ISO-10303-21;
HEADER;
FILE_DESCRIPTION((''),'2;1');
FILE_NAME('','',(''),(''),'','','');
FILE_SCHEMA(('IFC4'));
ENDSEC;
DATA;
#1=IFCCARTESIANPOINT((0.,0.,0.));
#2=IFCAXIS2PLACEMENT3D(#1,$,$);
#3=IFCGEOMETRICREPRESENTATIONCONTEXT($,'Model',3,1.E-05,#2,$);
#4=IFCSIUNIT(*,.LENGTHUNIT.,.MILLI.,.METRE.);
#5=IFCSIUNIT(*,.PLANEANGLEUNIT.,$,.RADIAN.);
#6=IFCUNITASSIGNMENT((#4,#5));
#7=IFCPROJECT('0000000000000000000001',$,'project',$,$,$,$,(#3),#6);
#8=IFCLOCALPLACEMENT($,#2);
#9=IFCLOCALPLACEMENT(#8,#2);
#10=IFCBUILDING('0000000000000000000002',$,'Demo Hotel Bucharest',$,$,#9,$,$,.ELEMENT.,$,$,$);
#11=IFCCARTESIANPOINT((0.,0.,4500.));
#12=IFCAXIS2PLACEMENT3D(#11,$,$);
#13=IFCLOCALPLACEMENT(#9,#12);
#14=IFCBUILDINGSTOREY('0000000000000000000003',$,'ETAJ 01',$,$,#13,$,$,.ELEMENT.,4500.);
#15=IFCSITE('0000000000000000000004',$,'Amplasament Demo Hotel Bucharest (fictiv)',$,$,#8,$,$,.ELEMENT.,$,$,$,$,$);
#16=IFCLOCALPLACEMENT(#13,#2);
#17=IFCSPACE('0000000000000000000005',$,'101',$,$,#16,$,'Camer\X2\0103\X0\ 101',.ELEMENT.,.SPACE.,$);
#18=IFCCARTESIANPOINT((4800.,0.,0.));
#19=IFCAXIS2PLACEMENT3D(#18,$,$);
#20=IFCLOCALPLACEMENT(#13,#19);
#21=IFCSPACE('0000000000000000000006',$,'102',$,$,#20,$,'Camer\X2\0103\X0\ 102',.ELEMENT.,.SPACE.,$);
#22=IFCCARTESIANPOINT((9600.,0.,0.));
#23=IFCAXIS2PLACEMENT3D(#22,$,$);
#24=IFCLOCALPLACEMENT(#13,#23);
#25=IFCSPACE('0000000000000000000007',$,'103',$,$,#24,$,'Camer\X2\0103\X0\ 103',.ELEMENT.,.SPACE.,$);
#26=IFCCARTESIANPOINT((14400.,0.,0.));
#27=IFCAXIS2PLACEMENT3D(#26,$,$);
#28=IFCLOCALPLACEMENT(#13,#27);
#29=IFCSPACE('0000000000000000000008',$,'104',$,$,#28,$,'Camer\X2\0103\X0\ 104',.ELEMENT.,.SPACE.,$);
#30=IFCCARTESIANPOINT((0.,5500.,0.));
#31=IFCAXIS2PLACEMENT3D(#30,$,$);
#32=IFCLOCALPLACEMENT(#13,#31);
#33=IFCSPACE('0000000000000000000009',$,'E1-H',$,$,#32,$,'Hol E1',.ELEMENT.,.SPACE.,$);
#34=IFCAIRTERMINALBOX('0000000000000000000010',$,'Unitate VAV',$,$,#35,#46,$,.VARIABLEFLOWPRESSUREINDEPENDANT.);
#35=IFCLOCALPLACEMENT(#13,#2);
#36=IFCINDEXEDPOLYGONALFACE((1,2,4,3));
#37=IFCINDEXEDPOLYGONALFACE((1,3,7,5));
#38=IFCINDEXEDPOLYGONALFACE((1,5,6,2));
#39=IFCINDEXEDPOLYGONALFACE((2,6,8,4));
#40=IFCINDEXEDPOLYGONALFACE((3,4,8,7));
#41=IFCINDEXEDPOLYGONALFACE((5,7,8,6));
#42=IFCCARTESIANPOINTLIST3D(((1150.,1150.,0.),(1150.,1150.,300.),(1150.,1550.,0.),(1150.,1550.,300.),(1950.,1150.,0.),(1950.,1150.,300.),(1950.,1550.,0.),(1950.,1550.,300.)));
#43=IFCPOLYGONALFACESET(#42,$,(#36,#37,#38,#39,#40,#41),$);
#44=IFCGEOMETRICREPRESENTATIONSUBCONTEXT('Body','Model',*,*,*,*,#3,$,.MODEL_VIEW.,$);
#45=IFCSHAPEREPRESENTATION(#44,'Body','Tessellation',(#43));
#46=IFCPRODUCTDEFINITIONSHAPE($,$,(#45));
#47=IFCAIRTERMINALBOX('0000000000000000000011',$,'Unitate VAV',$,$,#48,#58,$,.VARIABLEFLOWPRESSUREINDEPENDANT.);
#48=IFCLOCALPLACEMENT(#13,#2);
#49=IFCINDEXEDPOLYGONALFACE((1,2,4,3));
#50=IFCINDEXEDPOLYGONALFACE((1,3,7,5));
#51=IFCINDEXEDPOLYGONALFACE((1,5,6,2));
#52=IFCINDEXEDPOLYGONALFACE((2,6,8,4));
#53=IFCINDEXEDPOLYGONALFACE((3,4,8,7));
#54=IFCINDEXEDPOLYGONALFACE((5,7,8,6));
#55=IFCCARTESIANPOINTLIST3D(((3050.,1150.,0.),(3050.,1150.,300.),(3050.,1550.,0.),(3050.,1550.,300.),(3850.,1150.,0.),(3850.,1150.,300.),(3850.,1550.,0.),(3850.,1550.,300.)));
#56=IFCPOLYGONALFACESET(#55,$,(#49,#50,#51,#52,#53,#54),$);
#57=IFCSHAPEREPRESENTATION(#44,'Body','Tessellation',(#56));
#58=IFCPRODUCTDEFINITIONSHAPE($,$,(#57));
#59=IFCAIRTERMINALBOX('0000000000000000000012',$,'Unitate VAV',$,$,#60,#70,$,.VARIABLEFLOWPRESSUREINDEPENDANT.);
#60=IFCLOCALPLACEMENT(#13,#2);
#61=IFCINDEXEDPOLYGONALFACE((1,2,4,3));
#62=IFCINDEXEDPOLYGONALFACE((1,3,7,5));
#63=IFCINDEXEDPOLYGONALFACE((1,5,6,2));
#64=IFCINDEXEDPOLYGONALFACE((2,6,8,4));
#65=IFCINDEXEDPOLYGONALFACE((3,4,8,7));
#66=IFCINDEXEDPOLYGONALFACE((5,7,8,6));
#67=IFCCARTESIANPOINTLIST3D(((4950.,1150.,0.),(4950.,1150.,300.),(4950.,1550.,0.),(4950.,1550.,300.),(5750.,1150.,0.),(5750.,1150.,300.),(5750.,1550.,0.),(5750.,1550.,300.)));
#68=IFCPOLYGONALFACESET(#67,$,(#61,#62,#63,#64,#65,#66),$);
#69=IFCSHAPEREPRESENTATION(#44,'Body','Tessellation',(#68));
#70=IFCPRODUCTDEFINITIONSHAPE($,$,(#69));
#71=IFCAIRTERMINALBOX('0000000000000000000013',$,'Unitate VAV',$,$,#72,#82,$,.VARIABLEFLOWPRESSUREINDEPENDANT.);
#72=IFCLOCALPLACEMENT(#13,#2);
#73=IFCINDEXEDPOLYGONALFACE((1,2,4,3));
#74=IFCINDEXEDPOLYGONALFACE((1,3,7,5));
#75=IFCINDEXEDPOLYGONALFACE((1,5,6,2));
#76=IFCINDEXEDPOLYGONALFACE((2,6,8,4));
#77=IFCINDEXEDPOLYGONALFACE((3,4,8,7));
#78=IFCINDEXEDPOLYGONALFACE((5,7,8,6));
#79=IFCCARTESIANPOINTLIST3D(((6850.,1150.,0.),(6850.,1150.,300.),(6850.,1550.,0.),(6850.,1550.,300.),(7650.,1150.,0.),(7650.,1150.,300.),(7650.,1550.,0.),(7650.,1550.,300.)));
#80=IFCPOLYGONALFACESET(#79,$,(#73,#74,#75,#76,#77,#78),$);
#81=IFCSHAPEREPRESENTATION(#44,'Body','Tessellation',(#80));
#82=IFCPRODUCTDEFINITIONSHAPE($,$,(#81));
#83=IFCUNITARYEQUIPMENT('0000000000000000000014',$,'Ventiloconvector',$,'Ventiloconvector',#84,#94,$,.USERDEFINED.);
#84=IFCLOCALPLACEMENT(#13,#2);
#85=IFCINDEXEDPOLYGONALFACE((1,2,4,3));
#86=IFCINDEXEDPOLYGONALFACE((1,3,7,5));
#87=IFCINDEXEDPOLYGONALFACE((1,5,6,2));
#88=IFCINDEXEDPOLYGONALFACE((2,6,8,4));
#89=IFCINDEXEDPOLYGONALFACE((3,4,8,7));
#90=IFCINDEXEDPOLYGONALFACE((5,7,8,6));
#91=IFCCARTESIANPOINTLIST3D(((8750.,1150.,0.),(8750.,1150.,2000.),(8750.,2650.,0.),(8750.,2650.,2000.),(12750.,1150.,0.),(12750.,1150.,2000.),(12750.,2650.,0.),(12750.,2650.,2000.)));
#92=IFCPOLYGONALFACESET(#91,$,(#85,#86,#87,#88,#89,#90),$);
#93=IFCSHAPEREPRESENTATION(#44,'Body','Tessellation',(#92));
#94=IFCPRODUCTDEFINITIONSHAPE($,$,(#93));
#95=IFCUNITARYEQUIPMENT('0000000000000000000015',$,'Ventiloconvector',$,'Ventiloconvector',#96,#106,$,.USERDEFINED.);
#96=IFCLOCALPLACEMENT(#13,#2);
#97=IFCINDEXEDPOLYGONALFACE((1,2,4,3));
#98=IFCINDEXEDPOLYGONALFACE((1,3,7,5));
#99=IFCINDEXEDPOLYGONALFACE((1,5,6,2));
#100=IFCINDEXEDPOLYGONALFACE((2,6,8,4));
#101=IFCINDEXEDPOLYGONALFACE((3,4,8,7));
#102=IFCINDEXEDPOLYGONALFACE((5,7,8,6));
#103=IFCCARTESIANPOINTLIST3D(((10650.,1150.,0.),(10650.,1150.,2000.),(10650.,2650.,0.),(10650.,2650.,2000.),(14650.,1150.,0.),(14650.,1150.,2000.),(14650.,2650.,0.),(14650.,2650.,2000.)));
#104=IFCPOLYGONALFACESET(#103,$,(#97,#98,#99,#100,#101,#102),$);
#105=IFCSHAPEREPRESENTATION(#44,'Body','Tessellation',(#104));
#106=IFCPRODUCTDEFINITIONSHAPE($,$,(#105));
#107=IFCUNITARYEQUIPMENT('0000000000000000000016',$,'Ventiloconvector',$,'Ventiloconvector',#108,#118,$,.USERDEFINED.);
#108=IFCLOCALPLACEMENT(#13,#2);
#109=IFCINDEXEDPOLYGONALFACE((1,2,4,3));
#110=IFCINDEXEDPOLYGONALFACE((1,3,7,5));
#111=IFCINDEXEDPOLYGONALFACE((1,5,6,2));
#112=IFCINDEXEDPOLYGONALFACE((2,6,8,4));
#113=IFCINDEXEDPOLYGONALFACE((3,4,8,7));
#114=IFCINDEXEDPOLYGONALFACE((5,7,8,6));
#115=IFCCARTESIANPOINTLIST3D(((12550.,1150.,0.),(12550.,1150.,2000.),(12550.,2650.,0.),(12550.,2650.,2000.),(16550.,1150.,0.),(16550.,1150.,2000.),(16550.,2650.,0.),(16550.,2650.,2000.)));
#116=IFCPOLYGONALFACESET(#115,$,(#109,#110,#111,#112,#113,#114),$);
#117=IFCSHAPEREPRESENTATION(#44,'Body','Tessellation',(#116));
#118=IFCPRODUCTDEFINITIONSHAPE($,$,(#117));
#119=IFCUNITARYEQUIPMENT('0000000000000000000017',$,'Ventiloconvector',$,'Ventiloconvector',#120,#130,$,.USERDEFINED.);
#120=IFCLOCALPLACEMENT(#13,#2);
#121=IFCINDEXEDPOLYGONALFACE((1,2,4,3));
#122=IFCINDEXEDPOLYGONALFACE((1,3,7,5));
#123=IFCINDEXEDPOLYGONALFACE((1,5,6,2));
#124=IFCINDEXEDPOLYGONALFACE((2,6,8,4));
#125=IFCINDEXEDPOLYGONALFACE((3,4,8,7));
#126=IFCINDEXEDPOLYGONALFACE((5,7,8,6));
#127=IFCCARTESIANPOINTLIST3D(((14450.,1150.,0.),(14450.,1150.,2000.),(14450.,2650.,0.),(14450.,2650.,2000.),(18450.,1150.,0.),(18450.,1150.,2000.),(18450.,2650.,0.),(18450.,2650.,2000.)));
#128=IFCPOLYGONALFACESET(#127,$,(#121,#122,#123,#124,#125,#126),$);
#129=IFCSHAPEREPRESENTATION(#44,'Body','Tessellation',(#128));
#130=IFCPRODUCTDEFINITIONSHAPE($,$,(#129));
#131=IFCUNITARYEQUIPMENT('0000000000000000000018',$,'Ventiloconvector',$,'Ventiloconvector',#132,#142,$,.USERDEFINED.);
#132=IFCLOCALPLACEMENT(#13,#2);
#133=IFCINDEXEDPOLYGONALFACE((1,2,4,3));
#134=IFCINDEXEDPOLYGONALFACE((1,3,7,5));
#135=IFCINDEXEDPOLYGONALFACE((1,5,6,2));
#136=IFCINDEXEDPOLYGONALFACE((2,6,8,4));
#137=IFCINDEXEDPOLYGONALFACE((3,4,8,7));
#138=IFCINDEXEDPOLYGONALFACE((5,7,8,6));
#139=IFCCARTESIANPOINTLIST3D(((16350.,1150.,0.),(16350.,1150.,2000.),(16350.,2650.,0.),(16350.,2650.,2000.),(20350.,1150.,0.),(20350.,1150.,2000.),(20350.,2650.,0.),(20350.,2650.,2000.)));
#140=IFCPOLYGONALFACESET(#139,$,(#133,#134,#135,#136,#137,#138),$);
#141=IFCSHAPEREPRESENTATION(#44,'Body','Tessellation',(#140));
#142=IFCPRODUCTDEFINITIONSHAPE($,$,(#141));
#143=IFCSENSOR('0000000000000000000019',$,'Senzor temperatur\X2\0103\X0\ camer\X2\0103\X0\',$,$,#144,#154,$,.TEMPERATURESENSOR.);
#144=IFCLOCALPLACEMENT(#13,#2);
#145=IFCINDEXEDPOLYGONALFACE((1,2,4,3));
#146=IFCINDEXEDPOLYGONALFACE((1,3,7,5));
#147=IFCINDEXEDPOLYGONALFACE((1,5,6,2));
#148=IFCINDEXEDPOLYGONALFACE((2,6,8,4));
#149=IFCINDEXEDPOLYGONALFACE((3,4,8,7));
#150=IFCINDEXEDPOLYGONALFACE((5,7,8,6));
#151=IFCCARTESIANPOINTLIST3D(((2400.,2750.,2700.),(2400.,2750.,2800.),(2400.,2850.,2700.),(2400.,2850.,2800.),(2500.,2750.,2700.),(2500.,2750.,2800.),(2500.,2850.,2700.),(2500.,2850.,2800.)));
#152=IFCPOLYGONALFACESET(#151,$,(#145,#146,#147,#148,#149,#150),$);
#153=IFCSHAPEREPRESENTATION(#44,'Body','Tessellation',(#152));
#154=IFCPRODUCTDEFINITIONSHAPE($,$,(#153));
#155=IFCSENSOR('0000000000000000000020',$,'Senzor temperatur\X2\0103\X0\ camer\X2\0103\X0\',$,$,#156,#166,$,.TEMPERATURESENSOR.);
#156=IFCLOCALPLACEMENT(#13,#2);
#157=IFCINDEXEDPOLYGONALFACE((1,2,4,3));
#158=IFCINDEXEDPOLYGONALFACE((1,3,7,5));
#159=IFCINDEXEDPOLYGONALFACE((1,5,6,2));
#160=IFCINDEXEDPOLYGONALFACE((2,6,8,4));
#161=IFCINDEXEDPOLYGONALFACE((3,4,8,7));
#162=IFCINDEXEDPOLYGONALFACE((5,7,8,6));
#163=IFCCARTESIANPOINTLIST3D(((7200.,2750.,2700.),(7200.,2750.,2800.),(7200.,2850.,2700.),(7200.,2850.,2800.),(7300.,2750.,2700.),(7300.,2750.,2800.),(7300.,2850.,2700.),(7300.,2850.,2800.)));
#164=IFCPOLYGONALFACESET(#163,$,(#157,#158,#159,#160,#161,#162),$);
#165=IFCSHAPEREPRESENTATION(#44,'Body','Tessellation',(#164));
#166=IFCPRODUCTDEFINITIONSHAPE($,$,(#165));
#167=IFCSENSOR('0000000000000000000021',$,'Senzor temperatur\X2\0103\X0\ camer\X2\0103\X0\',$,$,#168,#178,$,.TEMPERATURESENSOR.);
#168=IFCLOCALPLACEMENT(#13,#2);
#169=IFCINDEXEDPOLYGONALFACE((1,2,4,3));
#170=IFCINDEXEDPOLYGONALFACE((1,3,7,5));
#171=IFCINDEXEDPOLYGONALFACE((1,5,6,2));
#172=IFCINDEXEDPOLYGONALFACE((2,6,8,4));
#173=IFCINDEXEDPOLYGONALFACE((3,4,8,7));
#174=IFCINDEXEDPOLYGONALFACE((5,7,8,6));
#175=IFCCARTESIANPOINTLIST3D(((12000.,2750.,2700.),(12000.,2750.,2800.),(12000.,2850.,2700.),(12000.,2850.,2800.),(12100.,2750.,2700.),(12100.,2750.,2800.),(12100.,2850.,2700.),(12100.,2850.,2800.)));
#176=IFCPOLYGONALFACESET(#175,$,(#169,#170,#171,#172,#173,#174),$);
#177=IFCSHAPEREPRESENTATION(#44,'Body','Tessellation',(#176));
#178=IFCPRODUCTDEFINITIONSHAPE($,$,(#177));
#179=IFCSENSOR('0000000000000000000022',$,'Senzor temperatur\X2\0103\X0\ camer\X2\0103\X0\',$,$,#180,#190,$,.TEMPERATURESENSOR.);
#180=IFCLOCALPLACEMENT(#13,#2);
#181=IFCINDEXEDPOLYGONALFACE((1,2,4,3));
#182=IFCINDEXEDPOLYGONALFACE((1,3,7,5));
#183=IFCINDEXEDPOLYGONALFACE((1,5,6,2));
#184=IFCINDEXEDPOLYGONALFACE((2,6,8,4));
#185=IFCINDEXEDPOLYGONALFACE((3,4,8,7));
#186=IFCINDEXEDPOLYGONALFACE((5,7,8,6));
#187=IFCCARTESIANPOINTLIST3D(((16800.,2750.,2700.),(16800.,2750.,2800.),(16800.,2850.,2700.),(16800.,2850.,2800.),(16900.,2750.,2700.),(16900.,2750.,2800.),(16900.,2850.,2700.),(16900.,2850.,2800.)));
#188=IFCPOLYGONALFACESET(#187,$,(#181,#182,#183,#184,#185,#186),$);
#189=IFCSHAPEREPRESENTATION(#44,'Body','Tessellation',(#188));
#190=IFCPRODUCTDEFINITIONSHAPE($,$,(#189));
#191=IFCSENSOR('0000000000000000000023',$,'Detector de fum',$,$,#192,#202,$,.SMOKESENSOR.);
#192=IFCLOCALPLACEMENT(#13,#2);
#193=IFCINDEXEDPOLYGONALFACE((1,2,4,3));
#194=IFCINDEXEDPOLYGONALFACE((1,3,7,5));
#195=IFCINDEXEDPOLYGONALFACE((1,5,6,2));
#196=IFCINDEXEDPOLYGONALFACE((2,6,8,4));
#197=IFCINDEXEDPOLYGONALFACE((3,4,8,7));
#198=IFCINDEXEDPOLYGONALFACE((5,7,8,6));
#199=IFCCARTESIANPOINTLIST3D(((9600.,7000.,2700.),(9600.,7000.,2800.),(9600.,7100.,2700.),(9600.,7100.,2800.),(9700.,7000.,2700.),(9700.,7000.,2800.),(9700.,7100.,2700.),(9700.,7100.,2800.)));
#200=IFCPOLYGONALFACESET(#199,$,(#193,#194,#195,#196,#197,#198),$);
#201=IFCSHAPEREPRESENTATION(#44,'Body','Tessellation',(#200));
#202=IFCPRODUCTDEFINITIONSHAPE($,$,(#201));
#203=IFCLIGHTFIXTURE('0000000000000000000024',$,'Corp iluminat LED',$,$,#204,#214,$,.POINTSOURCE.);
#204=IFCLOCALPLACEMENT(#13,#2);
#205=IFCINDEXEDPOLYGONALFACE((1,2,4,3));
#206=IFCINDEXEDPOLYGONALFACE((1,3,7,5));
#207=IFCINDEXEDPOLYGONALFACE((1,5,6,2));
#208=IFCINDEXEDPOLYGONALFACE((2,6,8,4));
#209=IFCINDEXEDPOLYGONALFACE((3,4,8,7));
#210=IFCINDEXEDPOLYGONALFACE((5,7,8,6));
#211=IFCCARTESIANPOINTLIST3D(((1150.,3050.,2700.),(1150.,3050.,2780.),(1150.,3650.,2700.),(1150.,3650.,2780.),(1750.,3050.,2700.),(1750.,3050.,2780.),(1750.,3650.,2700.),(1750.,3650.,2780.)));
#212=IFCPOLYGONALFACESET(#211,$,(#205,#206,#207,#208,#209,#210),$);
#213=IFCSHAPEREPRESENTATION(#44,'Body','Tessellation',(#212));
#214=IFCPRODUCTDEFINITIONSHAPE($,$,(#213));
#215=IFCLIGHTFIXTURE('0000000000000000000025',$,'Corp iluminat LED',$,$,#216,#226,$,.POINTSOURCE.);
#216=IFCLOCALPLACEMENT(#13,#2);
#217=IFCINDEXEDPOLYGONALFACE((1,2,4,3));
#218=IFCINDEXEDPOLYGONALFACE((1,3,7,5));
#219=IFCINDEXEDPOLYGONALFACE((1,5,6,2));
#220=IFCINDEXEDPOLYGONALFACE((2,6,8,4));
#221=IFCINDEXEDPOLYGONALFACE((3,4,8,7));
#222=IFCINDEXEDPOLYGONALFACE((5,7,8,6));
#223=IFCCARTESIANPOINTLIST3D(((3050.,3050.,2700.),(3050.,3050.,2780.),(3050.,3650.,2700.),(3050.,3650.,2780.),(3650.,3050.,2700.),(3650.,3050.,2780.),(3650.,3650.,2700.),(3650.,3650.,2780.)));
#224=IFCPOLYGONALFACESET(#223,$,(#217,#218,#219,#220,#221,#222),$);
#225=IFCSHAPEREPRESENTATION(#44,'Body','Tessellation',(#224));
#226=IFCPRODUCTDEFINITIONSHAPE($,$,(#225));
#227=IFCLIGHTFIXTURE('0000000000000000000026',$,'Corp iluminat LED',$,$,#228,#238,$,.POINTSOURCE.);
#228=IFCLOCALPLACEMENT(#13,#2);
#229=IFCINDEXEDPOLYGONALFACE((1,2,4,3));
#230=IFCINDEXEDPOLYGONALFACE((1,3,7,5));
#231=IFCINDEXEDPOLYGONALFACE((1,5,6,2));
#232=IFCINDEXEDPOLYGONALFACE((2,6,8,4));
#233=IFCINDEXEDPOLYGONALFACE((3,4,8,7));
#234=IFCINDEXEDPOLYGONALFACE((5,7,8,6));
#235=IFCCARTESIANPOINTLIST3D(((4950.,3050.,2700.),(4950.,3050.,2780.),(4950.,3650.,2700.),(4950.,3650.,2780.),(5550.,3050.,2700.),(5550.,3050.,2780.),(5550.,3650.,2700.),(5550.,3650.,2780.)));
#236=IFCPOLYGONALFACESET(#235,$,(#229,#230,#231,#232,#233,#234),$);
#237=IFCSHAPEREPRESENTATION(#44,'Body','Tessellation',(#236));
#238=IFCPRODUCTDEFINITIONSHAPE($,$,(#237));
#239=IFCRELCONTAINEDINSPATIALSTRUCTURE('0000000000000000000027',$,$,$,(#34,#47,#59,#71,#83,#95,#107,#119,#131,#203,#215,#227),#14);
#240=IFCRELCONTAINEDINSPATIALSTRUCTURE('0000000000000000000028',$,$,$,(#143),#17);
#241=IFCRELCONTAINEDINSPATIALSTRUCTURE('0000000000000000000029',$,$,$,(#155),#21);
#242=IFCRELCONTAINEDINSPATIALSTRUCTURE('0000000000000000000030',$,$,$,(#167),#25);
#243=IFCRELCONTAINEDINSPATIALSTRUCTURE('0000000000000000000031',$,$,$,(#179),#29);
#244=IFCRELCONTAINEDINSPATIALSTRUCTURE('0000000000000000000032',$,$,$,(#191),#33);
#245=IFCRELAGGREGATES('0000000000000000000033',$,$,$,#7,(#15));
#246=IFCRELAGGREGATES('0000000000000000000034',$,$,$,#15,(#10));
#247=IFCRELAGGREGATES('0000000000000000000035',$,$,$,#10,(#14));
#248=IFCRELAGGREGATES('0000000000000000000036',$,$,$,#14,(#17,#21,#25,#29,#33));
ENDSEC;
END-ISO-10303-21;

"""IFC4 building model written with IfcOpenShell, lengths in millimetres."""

from ifc_helpers import new_model, si_unit, frame, frame_2d, origin, place, context, subcontext, project, spatial, rectangle, extrude, element, save


model = new_model("IFC4")

# Units and contexts
model_context = context("Model", 3, precision=1e-05, world=origin())
body_context = subcontext(model_context, "Body", "Model", "MODEL_VIEW")
ifc_project = project(units=[si_unit("LENGTHUNIT", "METRE", prefix="MILLI"), si_unit("PLANEANGLEUNIT", "RADIAN")], contexts=[model_context])

# Site, building, storey
site_placement = place(None, origin())
site = spatial("IfcSite", under=ifc_project, at=site_placement, Name="Amplasament Demo Hotel Bucharest (fictiv)", CompositionType="ELEMENT")
building_placement = place(site_placement, origin())
building = spatial("IfcBuilding", under=site, at=building_placement, Name="Demo Hotel Bucharest", CompositionType="ELEMENT")
storey_placement = place(building_placement, frame((0.0, 0.0, 4500.0)))
storey = spatial("IfcBuildingStorey", under=building, at=storey_placement, Name="ETAJ 01", CompositionType="ELEMENT", Elevation=4500.0)

# Air terminal boxes
for number, where, name in (
    (1, (1150.0, 1150.0, 0.0), "Unitate VAV"),
    (2, (3050.0, 1150.0, 0.0), "Unitate VAV"),
    (3, (4950.0, 1150.0, 0.0), "Unitate VAV"),
    (4, (6850.0, 1150.0, 0.0), "Unitate VAV"),
):
    element("IfcAirTerminalBox", number, at=place(storey_placement, frame(where)), inside=storey, Name=name, PredefinedType="VARIABLEFLOWPRESSUREINDEPENDANT", context=body_context, shape_type="SweptSolid", body=[
        extrude(rectangle(XDim=800.0, YDim=400.0, at=frame_2d((400.0, 200.0))), origin(), (0.0, 0.0, 1.0), 300.0),
    ])

# Unitary equipment
for number, where, name in (
    (5, (8750.0, 1150.0, 0.0), "Ventiloconvector"),
    (6, (10650.0, 1150.0, 0.0), "Ventiloconvector"),
    (7, (12550.0, 1150.0, 0.0), "Ventiloconvector"),
    (8, (14450.0, 1150.0, 0.0), "Ventiloconvector"),
    (9, (16350.0, 1150.0, 0.0), "Ventiloconvector"),
):
    element("IfcUnitaryEquipment", number, at=place(storey_placement, frame(where)), inside=storey, Name=name, ObjectType="Ventiloconvector", PredefinedType="USERDEFINED", context=body_context, shape_type="SweptSolid", body=[
        extrude(rectangle(XDim=4000.0, YDim=1500.0, at=frame_2d((2000.0, 750.0))), origin(), (0.0, 0.0, 1.0), 2000.0),
    ])

# Shared definitions
space_1_placement = place(storey_placement, origin())
space_1 = spatial("IfcSpace", under=storey, at=space_1_placement, Name="101", LongName="Cameră 101", CompositionType="ELEMENT", PredefinedType="SPACE")

# Sensor
sensor_1_placement = place(storey_placement, frame((2400.0, 2750.0, 2700.0)))
element("IfcSensor", 10, at=sensor_1_placement, inside=space_1, Name="Senzor temperatură cameră", PredefinedType="TEMPERATURESENSOR", context=body_context, shape_type="SweptSolid", body=[
    extrude(rectangle(XDim=100.0, YDim=100.0, at=frame_2d((50.0, 50.0))), origin(), (0.0, 0.0, 1.0), 100.0),
])

# Shared definitions
space_2_placement = place(storey_placement, frame((4800.0, 0.0, 0.0)))
space_2 = spatial("IfcSpace", under=storey, at=space_2_placement, Name="102", LongName="Cameră 102", CompositionType="ELEMENT", PredefinedType="SPACE")

# Sensor
sensor_2_placement = place(storey_placement, frame((7200.0, 2750.0, 2700.0)))
element("IfcSensor", 11, at=sensor_2_placement, inside=space_2, Name="Senzor temperatură cameră", PredefinedType="TEMPERATURESENSOR", context=body_context, shape_type="SweptSolid", body=[
    extrude(rectangle(XDim=100.0, YDim=100.0, at=frame_2d((50.0, 50.0))), origin(), (0.0, 0.0, 1.0), 100.0),
])

# Shared definitions
space_3_placement = place(storey_placement, frame((9600.0, 0.0, 0.0)))
space_3 = spatial("IfcSpace", under=storey, at=space_3_placement, Name="103", LongName="Cameră 103", CompositionType="ELEMENT", PredefinedType="SPACE")

# Sensor
sensor_3_placement = place(storey_placement, frame((12000.0, 2750.0, 2700.0)))
element("IfcSensor", 12, at=sensor_3_placement, inside=space_3, Name="Senzor temperatură cameră", PredefinedType="TEMPERATURESENSOR", context=body_context, shape_type="SweptSolid", body=[
    extrude(rectangle(XDim=100.0, YDim=100.0, at=frame_2d((50.0, 50.0))), origin(), (0.0, 0.0, 1.0), 100.0),
])

# Shared definitions
space_4_placement = place(storey_placement, frame((14400.0, 0.0, 0.0)))
space_4 = spatial("IfcSpace", under=storey, at=space_4_placement, Name="104", LongName="Cameră 104", CompositionType="ELEMENT", PredefinedType="SPACE")

# Sensor
sensor_4_placement = place(storey_placement, frame((16800.0, 2750.0, 2700.0)))
element("IfcSensor", 13, at=sensor_4_placement, inside=space_4, Name="Senzor temperatură cameră", PredefinedType="TEMPERATURESENSOR", context=body_context, shape_type="SweptSolid", body=[
    extrude(rectangle(XDim=100.0, YDim=100.0, at=frame_2d((50.0, 50.0))), origin(), (0.0, 0.0, 1.0), 100.0),
])

# Shared definitions
space_5_placement = place(storey_placement, frame((0.0, 5500.0, 0.0)))
space_5 = spatial("IfcSpace", under=storey, at=space_5_placement, Name="E1-H", LongName="Hol E1", CompositionType="ELEMENT", PredefinedType="SPACE")

# Sensor
sensor_5_placement = place(storey_placement, frame((9600.0, 7000.0, 2700.0)))
element("IfcSensor", 14, at=sensor_5_placement, inside=space_5, Name="Detector de fum", PredefinedType="SMOKESENSOR", context=body_context, shape_type="SweptSolid", body=[
    extrude(rectangle(XDim=100.0, YDim=100.0, at=frame_2d((50.0, 50.0))), origin(), (0.0, 0.0, 1.0), 100.0),
])

# Light fixtures
for number, where, name in (
    (15, (1150.0, 3050.0, 2700.0), "Corp iluminat LED"),
    (16, (3050.0, 3050.0, 2700.0), "Corp iluminat LED"),
    (17, (4950.0, 3050.0, 2700.0), "Corp iluminat LED"),
):
    element("IfcLightFixture", number, at=place(storey_placement, frame(where)), inside=storey, Name=name, PredefinedType="POINTSOURCE", context=body_context, shape_type="SweptSolid", body=[
        extrude(rectangle(XDim=600.0, YDim=600.0, at=frame_2d((300.0, 300.0))), origin(), (0.0, 0.0, 1.0), 80.0),
    ])

save(model, "model.ifc")
